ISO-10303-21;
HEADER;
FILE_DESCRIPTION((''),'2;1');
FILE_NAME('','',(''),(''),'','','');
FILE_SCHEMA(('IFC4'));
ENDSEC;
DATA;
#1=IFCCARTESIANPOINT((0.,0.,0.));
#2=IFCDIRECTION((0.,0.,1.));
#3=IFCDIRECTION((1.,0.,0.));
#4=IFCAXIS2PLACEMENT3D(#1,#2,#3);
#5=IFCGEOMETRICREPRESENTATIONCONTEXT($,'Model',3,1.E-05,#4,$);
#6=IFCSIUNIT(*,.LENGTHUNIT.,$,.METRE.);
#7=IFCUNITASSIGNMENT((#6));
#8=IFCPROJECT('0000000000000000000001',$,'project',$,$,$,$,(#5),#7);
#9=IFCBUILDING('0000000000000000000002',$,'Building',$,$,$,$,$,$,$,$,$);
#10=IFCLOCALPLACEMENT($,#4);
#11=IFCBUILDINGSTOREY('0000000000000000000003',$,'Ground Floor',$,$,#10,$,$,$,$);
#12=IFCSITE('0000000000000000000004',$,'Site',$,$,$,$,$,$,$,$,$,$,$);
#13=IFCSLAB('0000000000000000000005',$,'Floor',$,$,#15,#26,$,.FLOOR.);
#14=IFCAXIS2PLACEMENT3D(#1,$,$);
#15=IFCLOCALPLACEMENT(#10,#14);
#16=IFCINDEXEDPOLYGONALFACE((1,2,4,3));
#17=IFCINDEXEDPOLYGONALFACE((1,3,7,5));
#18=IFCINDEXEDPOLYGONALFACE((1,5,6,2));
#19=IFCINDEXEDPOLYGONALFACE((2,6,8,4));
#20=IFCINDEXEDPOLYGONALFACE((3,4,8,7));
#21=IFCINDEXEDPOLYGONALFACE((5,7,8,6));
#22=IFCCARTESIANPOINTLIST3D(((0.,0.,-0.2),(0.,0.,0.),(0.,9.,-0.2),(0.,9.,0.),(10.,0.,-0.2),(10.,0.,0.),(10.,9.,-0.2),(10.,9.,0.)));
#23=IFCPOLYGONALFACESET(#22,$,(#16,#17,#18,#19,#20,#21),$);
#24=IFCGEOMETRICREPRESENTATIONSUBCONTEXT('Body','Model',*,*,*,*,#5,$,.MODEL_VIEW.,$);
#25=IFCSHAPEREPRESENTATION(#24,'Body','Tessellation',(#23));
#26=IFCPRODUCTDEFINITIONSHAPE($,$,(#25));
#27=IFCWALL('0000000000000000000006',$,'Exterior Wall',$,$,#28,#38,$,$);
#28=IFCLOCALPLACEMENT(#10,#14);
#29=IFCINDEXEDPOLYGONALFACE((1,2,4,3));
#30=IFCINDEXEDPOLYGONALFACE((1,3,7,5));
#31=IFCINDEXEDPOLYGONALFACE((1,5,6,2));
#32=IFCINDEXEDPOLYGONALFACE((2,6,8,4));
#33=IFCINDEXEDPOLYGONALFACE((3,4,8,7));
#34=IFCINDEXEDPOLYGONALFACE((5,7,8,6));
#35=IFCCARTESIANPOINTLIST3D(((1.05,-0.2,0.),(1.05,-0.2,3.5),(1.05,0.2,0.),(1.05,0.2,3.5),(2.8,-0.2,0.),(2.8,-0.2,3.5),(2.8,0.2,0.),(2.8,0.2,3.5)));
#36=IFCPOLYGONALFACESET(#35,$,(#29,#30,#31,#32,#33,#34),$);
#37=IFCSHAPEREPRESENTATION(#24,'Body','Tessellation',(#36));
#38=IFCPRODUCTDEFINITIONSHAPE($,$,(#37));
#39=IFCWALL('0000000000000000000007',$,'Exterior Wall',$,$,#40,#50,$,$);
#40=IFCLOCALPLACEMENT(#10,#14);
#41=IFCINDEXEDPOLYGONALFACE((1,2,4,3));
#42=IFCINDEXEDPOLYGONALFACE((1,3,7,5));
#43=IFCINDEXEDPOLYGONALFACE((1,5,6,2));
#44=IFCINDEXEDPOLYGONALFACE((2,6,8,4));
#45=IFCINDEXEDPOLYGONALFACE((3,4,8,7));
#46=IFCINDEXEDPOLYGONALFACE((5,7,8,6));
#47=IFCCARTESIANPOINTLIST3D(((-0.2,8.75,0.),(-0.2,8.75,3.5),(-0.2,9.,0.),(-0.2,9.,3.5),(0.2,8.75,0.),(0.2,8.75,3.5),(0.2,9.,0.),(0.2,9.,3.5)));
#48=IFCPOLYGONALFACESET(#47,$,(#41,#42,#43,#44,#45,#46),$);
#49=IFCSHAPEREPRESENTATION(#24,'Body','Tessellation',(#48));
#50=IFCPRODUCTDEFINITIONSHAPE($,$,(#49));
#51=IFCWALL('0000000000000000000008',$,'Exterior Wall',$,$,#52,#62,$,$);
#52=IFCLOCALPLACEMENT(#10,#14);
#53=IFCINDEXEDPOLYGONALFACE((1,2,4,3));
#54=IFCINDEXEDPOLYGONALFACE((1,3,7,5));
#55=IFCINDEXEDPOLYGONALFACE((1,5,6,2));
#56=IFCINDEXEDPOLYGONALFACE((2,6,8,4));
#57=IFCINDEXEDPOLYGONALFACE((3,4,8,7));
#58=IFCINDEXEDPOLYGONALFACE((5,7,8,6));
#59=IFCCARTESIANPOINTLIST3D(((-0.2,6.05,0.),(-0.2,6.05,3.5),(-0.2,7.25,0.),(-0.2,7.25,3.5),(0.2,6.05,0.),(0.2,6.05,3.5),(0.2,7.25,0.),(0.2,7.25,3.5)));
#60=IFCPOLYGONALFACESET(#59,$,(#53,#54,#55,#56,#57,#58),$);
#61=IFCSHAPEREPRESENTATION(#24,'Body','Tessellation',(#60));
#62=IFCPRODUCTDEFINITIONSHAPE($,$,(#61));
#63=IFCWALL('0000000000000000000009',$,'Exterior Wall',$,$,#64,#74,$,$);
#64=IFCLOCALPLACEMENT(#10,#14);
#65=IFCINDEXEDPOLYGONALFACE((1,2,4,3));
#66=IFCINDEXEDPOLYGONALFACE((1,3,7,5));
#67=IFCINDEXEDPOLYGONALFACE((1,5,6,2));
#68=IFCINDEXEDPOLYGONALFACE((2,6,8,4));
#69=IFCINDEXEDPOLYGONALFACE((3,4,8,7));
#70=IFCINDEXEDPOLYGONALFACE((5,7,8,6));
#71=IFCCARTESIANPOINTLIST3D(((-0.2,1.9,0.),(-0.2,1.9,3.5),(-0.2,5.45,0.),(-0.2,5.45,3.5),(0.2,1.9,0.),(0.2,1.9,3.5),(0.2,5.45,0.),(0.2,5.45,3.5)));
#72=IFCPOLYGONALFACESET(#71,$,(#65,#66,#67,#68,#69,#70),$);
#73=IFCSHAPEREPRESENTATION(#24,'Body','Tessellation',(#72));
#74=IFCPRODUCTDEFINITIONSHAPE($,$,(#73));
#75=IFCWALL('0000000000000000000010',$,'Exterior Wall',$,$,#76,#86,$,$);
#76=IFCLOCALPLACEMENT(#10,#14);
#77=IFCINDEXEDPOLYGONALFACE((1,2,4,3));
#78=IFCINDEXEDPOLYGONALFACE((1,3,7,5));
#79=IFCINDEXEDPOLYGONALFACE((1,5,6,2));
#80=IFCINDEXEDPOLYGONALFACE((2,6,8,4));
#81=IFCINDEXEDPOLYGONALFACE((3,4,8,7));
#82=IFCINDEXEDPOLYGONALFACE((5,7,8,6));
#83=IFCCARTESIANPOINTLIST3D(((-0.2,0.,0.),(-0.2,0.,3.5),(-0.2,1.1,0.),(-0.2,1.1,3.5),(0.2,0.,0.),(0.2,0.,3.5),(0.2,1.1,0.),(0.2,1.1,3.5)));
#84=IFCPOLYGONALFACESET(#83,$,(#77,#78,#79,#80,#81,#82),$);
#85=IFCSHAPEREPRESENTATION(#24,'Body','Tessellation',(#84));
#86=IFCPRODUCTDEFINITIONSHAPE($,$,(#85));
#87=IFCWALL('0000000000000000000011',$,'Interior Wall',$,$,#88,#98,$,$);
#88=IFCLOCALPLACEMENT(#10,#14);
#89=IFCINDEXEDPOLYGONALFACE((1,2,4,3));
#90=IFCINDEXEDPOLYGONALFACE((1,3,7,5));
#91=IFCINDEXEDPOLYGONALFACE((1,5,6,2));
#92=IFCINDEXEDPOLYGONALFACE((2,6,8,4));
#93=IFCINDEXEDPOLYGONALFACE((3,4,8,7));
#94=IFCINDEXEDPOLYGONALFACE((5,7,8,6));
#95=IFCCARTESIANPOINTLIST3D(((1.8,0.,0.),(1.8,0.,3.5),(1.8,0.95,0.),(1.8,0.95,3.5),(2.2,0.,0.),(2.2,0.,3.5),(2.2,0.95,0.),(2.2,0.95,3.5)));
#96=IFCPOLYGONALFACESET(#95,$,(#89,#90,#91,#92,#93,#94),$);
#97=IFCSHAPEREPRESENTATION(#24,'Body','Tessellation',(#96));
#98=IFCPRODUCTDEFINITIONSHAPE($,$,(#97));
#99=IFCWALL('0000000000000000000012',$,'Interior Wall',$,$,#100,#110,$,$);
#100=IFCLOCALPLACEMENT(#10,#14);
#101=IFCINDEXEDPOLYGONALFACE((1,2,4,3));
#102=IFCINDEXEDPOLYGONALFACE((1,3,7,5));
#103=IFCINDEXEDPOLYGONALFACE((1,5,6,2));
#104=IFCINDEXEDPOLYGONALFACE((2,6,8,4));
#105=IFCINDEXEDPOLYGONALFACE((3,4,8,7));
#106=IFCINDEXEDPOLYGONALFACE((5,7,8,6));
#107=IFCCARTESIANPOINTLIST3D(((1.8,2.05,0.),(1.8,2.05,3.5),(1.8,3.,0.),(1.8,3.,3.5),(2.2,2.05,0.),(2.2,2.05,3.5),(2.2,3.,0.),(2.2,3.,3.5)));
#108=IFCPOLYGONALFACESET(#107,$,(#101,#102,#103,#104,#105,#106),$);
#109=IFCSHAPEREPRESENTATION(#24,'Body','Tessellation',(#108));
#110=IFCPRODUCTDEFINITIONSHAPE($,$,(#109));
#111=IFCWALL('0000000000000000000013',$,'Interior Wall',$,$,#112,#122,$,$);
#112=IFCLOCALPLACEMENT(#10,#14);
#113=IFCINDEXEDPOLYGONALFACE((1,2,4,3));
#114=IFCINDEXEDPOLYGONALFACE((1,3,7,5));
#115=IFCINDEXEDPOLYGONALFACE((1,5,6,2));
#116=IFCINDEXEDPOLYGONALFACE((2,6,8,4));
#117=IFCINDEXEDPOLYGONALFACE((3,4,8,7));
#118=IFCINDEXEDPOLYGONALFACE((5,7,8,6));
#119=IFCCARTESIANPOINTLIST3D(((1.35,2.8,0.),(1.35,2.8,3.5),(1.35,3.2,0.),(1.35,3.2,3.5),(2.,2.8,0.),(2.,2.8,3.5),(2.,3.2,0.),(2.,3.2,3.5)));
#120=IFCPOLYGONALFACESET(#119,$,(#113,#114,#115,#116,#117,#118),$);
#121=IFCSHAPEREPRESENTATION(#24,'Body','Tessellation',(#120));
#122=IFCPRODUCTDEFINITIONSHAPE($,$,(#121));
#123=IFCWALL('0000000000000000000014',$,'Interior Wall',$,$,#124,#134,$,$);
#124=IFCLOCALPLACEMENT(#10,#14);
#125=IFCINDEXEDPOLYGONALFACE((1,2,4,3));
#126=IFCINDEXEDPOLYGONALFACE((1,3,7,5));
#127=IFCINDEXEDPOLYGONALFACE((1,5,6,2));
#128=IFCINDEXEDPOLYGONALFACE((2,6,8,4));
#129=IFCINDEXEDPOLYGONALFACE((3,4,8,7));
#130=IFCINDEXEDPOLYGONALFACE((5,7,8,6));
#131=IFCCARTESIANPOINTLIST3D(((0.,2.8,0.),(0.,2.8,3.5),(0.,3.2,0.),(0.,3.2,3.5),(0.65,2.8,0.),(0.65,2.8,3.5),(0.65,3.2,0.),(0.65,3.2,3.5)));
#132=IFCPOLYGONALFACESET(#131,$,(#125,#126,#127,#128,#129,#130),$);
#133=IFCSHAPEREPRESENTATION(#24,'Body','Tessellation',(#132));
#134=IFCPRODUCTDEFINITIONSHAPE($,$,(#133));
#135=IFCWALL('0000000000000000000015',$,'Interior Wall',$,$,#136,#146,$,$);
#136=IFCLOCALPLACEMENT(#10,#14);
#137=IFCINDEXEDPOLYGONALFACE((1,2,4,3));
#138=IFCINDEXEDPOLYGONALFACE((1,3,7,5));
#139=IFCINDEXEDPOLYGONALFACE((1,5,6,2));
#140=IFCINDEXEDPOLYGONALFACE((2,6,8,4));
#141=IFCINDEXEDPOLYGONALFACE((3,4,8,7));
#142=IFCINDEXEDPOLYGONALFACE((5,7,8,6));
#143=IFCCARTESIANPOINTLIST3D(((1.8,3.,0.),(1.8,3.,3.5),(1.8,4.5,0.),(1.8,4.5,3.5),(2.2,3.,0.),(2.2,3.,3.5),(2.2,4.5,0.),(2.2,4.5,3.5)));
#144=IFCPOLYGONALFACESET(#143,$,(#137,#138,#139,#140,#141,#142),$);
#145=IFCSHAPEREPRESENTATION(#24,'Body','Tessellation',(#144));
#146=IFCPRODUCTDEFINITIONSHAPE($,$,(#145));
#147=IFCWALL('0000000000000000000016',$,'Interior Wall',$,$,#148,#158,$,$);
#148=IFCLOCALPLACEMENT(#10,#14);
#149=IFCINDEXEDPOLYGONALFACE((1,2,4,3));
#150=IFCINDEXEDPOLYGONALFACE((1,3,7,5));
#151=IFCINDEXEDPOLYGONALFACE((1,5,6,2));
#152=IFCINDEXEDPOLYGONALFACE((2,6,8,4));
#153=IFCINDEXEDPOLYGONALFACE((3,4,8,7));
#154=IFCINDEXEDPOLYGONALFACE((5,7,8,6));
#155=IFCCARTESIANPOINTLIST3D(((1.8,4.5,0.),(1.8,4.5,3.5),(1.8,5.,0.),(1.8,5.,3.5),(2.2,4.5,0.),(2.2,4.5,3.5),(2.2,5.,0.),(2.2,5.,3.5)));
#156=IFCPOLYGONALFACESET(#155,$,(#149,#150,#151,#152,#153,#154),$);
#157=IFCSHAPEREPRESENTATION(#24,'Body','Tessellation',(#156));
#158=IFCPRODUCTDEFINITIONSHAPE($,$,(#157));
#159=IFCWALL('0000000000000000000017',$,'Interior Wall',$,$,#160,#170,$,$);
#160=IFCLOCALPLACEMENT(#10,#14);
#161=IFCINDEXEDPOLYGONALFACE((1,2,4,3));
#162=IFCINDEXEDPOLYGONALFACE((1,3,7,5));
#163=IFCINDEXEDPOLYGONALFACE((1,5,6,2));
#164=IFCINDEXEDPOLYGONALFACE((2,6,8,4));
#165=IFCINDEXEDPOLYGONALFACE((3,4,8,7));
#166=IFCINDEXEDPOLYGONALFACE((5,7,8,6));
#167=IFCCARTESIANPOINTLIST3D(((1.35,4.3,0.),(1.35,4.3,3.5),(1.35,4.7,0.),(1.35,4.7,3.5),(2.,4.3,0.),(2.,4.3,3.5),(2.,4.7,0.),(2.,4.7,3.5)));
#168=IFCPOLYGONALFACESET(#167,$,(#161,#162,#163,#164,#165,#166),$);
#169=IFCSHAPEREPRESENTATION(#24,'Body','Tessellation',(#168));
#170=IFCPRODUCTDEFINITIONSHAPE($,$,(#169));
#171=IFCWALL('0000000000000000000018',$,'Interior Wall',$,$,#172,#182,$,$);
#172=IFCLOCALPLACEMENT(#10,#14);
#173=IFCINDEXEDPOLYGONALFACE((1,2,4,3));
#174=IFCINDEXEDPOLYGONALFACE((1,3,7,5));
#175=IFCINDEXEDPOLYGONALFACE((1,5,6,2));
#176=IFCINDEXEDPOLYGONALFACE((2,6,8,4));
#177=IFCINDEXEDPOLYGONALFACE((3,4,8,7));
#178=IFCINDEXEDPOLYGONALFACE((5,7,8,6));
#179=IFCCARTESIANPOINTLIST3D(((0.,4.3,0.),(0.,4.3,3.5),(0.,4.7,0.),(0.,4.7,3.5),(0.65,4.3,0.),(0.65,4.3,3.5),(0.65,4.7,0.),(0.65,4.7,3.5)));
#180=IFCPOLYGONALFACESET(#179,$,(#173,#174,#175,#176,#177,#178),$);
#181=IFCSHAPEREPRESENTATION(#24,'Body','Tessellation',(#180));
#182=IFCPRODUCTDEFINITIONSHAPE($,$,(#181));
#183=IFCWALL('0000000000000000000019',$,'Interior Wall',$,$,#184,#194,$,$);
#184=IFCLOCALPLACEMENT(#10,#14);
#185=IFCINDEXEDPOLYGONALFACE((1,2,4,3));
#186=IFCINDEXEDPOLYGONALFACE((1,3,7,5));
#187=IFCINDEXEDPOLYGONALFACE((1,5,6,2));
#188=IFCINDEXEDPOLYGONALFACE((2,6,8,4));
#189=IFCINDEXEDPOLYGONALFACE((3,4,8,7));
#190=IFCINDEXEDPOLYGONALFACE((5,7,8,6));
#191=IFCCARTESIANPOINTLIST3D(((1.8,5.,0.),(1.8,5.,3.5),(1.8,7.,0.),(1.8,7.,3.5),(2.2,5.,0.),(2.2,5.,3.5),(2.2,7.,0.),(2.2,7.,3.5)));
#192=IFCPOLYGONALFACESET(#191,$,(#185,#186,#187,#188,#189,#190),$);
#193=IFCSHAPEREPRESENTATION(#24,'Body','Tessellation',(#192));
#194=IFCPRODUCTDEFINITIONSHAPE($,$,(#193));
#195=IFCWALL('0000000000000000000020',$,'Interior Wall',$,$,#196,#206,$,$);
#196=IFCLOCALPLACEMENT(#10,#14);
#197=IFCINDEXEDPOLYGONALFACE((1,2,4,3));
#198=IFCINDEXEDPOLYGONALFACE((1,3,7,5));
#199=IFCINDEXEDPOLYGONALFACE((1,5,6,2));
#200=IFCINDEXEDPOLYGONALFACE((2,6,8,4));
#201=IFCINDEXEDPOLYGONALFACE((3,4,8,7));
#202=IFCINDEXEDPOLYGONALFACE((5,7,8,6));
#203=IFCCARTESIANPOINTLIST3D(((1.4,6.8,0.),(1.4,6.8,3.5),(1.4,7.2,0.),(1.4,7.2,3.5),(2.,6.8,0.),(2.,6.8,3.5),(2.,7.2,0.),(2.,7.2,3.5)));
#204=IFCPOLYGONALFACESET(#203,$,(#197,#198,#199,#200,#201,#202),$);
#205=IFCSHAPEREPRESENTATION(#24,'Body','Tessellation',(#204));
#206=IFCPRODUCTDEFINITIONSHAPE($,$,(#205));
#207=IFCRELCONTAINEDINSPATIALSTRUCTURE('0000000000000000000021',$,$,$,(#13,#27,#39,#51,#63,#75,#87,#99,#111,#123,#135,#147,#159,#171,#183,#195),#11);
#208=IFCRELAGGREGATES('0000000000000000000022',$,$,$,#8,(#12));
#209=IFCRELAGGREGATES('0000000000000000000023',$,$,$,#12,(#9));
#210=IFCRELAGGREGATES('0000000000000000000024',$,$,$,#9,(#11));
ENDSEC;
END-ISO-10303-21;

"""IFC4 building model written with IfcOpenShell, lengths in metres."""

from ifc_helpers import new_model, si_unit, frame, origin_with_axes, place, context, subcontext, project, spatial, indexed_curve, outline, extrude, element, save


model = new_model("IFC4")

# Units and contexts
model_context = context("Model", 3, precision=1e-05, world=origin_with_axes())
body_context = subcontext(model_context, "Body", "Model", "MODEL_VIEW")
ifc_project = project(units=[si_unit("LENGTHUNIT", "METRE")], contexts=[model_context])

# Site, building, storey
site = spatial("IfcSite", under=ifc_project, Name="Site")
building = spatial("IfcBuilding", under=site, Name="Building")
storey_placement = place(None, origin_with_axes())
storey = spatial("IfcBuildingStorey", under=building, at=storey_placement, Name="Ground Floor")

# Slab
slab_placement = place(storey_placement, frame((0.0, 0.0, -0.2), z_axis=(0.0, 0.0, 1.0), x_axis=(1.0, 0.0, 0.0)))
element("IfcSlab", 1, at=slab_placement, inside=storey, Name="Floor", PredefinedType="FLOOR", context=body_context, shape_type="SweptSolid", body=[
    extrude(outline(indexed_curve([(0.0, 0.0), (10.0, 0.0), (10.0, 9.0), (0.0, 9.0)])), None, (0.0, 0.0, 1.0), 0.2),
])

# Walls
wall_1_placement = place(storey_placement, frame((1.05, 0.0, 0.0), z_axis=(0.0, 0.0, 1.0), x_axis=(1.0, 0.0, 0.0)))
element("IfcWall", 2, at=wall_1_placement, inside=storey, Name="Exterior Wall", context=body_context, shape_type="SweptSolid", body=[
    extrude(outline(indexed_curve([(0.0, 0.0), (0.0, 0.4), (1.75, 0.4), (1.75, 0.0), (0.0, 0.0)], self_intersect=False)), frame((0.0, -0.2, 0.0), z_axis=(0.0, 0.0, 1.0), x_axis=(1.0, 0.0, 0.0)), (0.0, 0.0, 1.0), 3.5),
])
wall_2_placement = place(storey_placement, frame((0.0, 9.0, 0.0), z_axis=(0.0, 0.0, 1.0), x_axis=(0.0, -1.0, 0.0)))
element("IfcWall", 3, at=wall_2_placement, inside=storey, Name="Exterior Wall", context=body_context, shape_type="SweptSolid", body=[
    extrude(outline(indexed_curve([(0.0, 0.0), (0.0, 0.4), (0.25, 0.4), (0.25, 0.0), (0.0, 0.0)], self_intersect=False)), frame((0.0, -0.2, 0.0), z_axis=(0.0, 0.0, 1.0), x_axis=(1.0, 0.0, 0.0)), (0.0, 0.0, 1.0), 3.5),
])
wall_3_placement = place(storey_placement, frame((0.0, 7.25, 0.0), z_axis=(0.0, 0.0, 1.0), x_axis=(0.0, -1.0, 0.0)))
element("IfcWall", 4, at=wall_3_placement, inside=storey, Name="Exterior Wall", context=body_context, shape_type="SweptSolid", body=[
    extrude(outline(indexed_curve([(0.0, 0.0), (0.0, 0.4), (1.2, 0.4), (1.2, 0.0), (0.0, 0.0)], self_intersect=False)), frame((0.0, -0.2, 0.0), z_axis=(0.0, 0.0, 1.0), x_axis=(1.0, 0.0, 0.0)), (0.0, 0.0, 1.0), 3.5),
])
wall_4_placement = place(storey_placement, frame((0.0, 5.45, 0.0), z_axis=(0.0, 0.0, 1.0), x_axis=(0.0, -1.0, 0.0)))
element("IfcWall", 5, at=wall_4_placement, inside=storey, Name="Exterior Wall", context=body_context, shape_type="SweptSolid", body=[
    extrude(outline(indexed_curve([(0.0, 0.0), (0.0, 0.4), (3.55, 0.4), (3.55, 0.0), (0.0, 0.0)], self_intersect=False)), frame((0.0, -0.2, 0.0), z_axis=(0.0, 0.0, 1.0), x_axis=(1.0, 0.0, 0.0)), (0.0, 0.0, 1.0), 3.5),
])
wall_5_placement = place(storey_placement, frame((0.0, 1.1, 0.0), z_axis=(0.0, 0.0, 1.0), x_axis=(0.0, -1.0, 0.0)))
element("IfcWall", 6, at=wall_5_placement, inside=storey, Name="Exterior Wall", context=body_context, shape_type="SweptSolid", body=[
    extrude(outline(indexed_curve([(0.0, 0.0), (0.0, 0.4), (1.1, 0.4), (1.1, 0.0), (0.0, 0.0)], self_intersect=False)), frame((0.0, -0.2, 0.0), z_axis=(0.0, 0.0, 1.0), x_axis=(1.0, 0.0, 0.0)), (0.0, 0.0, 1.0), 3.5),
])
wall_6_placement = place(storey_placement, frame((2.0, 0.0, 0.0), z_axis=(0.0, 0.0, 1.0), x_axis=(0.0, 1.0, 0.0)))
element("IfcWall", 7, at=wall_6_placement, inside=storey, Name="Interior Wall", context=body_context, shape_type="SweptSolid", body=[
    extrude(outline(indexed_curve([(0.0, 0.0), (0.0, 0.4), (0.95, 0.4), (0.95, 0.0), (0.0, 0.0)], self_intersect=False)), frame((0.0, -0.2, 0.0), z_axis=(0.0, 0.0, 1.0), x_axis=(1.0, 0.0, 0.0)), (0.0, 0.0, 1.0), 3.5),
])
wall_7_placement = place(storey_placement, frame((2.0, 2.05, 0.0), z_axis=(0.0, 0.0, 1.0), x_axis=(0.0, 1.0, 0.0)))
element("IfcWall", 8, at=wall_7_placement, inside=storey, Name="Interior Wall", context=body_context, shape_type="SweptSolid", body=[
    extrude(outline(indexed_curve([(0.0, 0.0), (0.0, 0.4), (0.95, 0.4), (0.95, 0.0), (0.0, 0.0)], self_intersect=False)), frame((0.0, -0.2, 0.0), z_axis=(0.0, 0.0, 1.0), x_axis=(1.0, 0.0, 0.0)), (0.0, 0.0, 1.0), 3.5),
])
for number, where, z_axis, x_axis, name in (
    (9, (2.0, 3.0, 0.0), (0.0, 0.0, 1.0), (-1.0, 0.0, 0.0), "Interior Wall"),
    (10, (0.65, 3.0, 0.0), (0.0, 0.0, 1.0), (-1.0, 0.0, 0.0), "Interior Wall"),
):
    element("IfcWall", number, at=place(storey_placement, frame(where, z_axis=z_axis, x_axis=x_axis)), inside=storey, Name=name, context=body_context, shape_type="SweptSolid", body=[
        extrude(outline(indexed_curve([(0.0, 0.0), (0.0, 0.4), (0.65, 0.4), (0.65, 0.0), (0.0, 0.0)], self_intersect=False)), frame((0.0, -0.2, 0.0), z_axis=(0.0, 0.0, 1.0), x_axis=(1.0, 0.0, 0.0)), (0.0, 0.0, 1.0), 3.5),
    ])
wall_8_placement = place(storey_placement, frame((2.0, 4.5, 0.0), z_axis=(0.0, 0.0, 1.0), x_axis=(0.0, -1.0, 0.0)))
element("IfcWall", 11, at=wall_8_placement, inside=storey, Name="Interior Wall", context=body_context, shape_type="SweptSolid", body=[
    extrude(outline(indexed_curve([(0.0, 0.0), (0.0, 0.4), (1.5, 0.4), (1.5, 0.0), (0.0, 0.0)], self_intersect=False)), frame((0.0, -0.2, 0.0), z_axis=(0.0, 0.0, 1.0), x_axis=(1.0, 0.0, 0.0)), (0.0, 0.0, 1.0), 3.5),
])
wall_9_placement = place(storey_placement, frame((2.0, 5.0, 0.0), z_axis=(0.0, 0.0, 1.0), x_axis=(0.0, -1.0, 0.0)))
element("IfcWall", 12, at=wall_9_placement, inside=storey, Name="Interior Wall", context=body_context, shape_type="SweptSolid", body=[
    extrude(outline(indexed_curve([(0.0, 0.0), (0.0, 0.4), (0.5, 0.4), (0.5, 0.0), (0.0, 0.0)], self_intersect=False)), frame((0.0, -0.2, 0.0), z_axis=(0.0, 0.0, 1.0), x_axis=(1.0, 0.0, 0.0)), (0.0, 0.0, 1.0), 3.5),
])
for number, where, z_axis, x_axis, name in (
    (13, (2.0, 4.5, 0.0), (0.0, 0.0, 1.0), (-1.0, 0.0, 0.0), "Interior Wall"),
    (14, (0.65, 4.5, 0.0), (0.0, 0.0, 1.0), (-1.0, 0.0, 0.0), "Interior Wall"),
):
    element("IfcWall", number, at=place(storey_placement, frame(where, z_axis=z_axis, x_axis=x_axis)), inside=storey, Name=name, context=body_context, shape_type="SweptSolid", body=[
        extrude(outline(indexed_curve([(0.0, 0.0), (0.0, 0.4), (0.65, 0.4), (0.65, 0.0), (0.0, 0.0)], self_intersect=False)), frame((0.0, -0.2, 0.0), z_axis=(0.0, 0.0, 1.0), x_axis=(1.0, 0.0, 0.0)), (0.0, 0.0, 1.0), 3.5),
    ])
wall_10_placement = place(storey_placement, frame((2.0, 5.0, 0.0), z_axis=(0.0, 0.0, 1.0), x_axis=(0.0, 1.0, 0.0)))
element("IfcWall", 15, at=wall_10_placement, inside=storey, Name="Interior Wall", context=body_context, shape_type="SweptSolid", body=[
    extrude(outline(indexed_curve([(0.0, 0.0), (0.0, 0.4), (2.0, 0.4), (2.0, 0.0), (0.0, 0.0)], self_intersect=False)), frame((0.0, -0.2, 0.0), z_axis=(0.0, 0.0, 1.0), x_axis=(1.0, 0.0, 0.0)), (0.0, 0.0, 1.0), 3.5),
])
for number, where, z_axis, x_axis, name in (
    (16, (2.0, 7.0, 0.0), (0.0, 0.0, 1.0), (-1.0, 0.0, 0.0), "Interior Wall"),
):
    element("IfcWall", number, at=place(storey_placement, frame(where, z_axis=z_axis, x_axis=x_axis)), inside=storey, Name=name, context=body_context, shape_type="SweptSolid", body=[
        extrude(outline(indexed_curve([(0.0, 0.0), (0.0, 0.4), (0.6, 0.4), (0.6, 0.0), (0.0, 0.0)], self_intersect=False)), frame((0.0, -0.2, 0.0), z_axis=(0.0, 0.0, 1.0), x_axis=(1.0, 0.0, 0.0)), (0.0, 0.0, 1.0), 3.5),
    ])

save(model, "model.ifc")
